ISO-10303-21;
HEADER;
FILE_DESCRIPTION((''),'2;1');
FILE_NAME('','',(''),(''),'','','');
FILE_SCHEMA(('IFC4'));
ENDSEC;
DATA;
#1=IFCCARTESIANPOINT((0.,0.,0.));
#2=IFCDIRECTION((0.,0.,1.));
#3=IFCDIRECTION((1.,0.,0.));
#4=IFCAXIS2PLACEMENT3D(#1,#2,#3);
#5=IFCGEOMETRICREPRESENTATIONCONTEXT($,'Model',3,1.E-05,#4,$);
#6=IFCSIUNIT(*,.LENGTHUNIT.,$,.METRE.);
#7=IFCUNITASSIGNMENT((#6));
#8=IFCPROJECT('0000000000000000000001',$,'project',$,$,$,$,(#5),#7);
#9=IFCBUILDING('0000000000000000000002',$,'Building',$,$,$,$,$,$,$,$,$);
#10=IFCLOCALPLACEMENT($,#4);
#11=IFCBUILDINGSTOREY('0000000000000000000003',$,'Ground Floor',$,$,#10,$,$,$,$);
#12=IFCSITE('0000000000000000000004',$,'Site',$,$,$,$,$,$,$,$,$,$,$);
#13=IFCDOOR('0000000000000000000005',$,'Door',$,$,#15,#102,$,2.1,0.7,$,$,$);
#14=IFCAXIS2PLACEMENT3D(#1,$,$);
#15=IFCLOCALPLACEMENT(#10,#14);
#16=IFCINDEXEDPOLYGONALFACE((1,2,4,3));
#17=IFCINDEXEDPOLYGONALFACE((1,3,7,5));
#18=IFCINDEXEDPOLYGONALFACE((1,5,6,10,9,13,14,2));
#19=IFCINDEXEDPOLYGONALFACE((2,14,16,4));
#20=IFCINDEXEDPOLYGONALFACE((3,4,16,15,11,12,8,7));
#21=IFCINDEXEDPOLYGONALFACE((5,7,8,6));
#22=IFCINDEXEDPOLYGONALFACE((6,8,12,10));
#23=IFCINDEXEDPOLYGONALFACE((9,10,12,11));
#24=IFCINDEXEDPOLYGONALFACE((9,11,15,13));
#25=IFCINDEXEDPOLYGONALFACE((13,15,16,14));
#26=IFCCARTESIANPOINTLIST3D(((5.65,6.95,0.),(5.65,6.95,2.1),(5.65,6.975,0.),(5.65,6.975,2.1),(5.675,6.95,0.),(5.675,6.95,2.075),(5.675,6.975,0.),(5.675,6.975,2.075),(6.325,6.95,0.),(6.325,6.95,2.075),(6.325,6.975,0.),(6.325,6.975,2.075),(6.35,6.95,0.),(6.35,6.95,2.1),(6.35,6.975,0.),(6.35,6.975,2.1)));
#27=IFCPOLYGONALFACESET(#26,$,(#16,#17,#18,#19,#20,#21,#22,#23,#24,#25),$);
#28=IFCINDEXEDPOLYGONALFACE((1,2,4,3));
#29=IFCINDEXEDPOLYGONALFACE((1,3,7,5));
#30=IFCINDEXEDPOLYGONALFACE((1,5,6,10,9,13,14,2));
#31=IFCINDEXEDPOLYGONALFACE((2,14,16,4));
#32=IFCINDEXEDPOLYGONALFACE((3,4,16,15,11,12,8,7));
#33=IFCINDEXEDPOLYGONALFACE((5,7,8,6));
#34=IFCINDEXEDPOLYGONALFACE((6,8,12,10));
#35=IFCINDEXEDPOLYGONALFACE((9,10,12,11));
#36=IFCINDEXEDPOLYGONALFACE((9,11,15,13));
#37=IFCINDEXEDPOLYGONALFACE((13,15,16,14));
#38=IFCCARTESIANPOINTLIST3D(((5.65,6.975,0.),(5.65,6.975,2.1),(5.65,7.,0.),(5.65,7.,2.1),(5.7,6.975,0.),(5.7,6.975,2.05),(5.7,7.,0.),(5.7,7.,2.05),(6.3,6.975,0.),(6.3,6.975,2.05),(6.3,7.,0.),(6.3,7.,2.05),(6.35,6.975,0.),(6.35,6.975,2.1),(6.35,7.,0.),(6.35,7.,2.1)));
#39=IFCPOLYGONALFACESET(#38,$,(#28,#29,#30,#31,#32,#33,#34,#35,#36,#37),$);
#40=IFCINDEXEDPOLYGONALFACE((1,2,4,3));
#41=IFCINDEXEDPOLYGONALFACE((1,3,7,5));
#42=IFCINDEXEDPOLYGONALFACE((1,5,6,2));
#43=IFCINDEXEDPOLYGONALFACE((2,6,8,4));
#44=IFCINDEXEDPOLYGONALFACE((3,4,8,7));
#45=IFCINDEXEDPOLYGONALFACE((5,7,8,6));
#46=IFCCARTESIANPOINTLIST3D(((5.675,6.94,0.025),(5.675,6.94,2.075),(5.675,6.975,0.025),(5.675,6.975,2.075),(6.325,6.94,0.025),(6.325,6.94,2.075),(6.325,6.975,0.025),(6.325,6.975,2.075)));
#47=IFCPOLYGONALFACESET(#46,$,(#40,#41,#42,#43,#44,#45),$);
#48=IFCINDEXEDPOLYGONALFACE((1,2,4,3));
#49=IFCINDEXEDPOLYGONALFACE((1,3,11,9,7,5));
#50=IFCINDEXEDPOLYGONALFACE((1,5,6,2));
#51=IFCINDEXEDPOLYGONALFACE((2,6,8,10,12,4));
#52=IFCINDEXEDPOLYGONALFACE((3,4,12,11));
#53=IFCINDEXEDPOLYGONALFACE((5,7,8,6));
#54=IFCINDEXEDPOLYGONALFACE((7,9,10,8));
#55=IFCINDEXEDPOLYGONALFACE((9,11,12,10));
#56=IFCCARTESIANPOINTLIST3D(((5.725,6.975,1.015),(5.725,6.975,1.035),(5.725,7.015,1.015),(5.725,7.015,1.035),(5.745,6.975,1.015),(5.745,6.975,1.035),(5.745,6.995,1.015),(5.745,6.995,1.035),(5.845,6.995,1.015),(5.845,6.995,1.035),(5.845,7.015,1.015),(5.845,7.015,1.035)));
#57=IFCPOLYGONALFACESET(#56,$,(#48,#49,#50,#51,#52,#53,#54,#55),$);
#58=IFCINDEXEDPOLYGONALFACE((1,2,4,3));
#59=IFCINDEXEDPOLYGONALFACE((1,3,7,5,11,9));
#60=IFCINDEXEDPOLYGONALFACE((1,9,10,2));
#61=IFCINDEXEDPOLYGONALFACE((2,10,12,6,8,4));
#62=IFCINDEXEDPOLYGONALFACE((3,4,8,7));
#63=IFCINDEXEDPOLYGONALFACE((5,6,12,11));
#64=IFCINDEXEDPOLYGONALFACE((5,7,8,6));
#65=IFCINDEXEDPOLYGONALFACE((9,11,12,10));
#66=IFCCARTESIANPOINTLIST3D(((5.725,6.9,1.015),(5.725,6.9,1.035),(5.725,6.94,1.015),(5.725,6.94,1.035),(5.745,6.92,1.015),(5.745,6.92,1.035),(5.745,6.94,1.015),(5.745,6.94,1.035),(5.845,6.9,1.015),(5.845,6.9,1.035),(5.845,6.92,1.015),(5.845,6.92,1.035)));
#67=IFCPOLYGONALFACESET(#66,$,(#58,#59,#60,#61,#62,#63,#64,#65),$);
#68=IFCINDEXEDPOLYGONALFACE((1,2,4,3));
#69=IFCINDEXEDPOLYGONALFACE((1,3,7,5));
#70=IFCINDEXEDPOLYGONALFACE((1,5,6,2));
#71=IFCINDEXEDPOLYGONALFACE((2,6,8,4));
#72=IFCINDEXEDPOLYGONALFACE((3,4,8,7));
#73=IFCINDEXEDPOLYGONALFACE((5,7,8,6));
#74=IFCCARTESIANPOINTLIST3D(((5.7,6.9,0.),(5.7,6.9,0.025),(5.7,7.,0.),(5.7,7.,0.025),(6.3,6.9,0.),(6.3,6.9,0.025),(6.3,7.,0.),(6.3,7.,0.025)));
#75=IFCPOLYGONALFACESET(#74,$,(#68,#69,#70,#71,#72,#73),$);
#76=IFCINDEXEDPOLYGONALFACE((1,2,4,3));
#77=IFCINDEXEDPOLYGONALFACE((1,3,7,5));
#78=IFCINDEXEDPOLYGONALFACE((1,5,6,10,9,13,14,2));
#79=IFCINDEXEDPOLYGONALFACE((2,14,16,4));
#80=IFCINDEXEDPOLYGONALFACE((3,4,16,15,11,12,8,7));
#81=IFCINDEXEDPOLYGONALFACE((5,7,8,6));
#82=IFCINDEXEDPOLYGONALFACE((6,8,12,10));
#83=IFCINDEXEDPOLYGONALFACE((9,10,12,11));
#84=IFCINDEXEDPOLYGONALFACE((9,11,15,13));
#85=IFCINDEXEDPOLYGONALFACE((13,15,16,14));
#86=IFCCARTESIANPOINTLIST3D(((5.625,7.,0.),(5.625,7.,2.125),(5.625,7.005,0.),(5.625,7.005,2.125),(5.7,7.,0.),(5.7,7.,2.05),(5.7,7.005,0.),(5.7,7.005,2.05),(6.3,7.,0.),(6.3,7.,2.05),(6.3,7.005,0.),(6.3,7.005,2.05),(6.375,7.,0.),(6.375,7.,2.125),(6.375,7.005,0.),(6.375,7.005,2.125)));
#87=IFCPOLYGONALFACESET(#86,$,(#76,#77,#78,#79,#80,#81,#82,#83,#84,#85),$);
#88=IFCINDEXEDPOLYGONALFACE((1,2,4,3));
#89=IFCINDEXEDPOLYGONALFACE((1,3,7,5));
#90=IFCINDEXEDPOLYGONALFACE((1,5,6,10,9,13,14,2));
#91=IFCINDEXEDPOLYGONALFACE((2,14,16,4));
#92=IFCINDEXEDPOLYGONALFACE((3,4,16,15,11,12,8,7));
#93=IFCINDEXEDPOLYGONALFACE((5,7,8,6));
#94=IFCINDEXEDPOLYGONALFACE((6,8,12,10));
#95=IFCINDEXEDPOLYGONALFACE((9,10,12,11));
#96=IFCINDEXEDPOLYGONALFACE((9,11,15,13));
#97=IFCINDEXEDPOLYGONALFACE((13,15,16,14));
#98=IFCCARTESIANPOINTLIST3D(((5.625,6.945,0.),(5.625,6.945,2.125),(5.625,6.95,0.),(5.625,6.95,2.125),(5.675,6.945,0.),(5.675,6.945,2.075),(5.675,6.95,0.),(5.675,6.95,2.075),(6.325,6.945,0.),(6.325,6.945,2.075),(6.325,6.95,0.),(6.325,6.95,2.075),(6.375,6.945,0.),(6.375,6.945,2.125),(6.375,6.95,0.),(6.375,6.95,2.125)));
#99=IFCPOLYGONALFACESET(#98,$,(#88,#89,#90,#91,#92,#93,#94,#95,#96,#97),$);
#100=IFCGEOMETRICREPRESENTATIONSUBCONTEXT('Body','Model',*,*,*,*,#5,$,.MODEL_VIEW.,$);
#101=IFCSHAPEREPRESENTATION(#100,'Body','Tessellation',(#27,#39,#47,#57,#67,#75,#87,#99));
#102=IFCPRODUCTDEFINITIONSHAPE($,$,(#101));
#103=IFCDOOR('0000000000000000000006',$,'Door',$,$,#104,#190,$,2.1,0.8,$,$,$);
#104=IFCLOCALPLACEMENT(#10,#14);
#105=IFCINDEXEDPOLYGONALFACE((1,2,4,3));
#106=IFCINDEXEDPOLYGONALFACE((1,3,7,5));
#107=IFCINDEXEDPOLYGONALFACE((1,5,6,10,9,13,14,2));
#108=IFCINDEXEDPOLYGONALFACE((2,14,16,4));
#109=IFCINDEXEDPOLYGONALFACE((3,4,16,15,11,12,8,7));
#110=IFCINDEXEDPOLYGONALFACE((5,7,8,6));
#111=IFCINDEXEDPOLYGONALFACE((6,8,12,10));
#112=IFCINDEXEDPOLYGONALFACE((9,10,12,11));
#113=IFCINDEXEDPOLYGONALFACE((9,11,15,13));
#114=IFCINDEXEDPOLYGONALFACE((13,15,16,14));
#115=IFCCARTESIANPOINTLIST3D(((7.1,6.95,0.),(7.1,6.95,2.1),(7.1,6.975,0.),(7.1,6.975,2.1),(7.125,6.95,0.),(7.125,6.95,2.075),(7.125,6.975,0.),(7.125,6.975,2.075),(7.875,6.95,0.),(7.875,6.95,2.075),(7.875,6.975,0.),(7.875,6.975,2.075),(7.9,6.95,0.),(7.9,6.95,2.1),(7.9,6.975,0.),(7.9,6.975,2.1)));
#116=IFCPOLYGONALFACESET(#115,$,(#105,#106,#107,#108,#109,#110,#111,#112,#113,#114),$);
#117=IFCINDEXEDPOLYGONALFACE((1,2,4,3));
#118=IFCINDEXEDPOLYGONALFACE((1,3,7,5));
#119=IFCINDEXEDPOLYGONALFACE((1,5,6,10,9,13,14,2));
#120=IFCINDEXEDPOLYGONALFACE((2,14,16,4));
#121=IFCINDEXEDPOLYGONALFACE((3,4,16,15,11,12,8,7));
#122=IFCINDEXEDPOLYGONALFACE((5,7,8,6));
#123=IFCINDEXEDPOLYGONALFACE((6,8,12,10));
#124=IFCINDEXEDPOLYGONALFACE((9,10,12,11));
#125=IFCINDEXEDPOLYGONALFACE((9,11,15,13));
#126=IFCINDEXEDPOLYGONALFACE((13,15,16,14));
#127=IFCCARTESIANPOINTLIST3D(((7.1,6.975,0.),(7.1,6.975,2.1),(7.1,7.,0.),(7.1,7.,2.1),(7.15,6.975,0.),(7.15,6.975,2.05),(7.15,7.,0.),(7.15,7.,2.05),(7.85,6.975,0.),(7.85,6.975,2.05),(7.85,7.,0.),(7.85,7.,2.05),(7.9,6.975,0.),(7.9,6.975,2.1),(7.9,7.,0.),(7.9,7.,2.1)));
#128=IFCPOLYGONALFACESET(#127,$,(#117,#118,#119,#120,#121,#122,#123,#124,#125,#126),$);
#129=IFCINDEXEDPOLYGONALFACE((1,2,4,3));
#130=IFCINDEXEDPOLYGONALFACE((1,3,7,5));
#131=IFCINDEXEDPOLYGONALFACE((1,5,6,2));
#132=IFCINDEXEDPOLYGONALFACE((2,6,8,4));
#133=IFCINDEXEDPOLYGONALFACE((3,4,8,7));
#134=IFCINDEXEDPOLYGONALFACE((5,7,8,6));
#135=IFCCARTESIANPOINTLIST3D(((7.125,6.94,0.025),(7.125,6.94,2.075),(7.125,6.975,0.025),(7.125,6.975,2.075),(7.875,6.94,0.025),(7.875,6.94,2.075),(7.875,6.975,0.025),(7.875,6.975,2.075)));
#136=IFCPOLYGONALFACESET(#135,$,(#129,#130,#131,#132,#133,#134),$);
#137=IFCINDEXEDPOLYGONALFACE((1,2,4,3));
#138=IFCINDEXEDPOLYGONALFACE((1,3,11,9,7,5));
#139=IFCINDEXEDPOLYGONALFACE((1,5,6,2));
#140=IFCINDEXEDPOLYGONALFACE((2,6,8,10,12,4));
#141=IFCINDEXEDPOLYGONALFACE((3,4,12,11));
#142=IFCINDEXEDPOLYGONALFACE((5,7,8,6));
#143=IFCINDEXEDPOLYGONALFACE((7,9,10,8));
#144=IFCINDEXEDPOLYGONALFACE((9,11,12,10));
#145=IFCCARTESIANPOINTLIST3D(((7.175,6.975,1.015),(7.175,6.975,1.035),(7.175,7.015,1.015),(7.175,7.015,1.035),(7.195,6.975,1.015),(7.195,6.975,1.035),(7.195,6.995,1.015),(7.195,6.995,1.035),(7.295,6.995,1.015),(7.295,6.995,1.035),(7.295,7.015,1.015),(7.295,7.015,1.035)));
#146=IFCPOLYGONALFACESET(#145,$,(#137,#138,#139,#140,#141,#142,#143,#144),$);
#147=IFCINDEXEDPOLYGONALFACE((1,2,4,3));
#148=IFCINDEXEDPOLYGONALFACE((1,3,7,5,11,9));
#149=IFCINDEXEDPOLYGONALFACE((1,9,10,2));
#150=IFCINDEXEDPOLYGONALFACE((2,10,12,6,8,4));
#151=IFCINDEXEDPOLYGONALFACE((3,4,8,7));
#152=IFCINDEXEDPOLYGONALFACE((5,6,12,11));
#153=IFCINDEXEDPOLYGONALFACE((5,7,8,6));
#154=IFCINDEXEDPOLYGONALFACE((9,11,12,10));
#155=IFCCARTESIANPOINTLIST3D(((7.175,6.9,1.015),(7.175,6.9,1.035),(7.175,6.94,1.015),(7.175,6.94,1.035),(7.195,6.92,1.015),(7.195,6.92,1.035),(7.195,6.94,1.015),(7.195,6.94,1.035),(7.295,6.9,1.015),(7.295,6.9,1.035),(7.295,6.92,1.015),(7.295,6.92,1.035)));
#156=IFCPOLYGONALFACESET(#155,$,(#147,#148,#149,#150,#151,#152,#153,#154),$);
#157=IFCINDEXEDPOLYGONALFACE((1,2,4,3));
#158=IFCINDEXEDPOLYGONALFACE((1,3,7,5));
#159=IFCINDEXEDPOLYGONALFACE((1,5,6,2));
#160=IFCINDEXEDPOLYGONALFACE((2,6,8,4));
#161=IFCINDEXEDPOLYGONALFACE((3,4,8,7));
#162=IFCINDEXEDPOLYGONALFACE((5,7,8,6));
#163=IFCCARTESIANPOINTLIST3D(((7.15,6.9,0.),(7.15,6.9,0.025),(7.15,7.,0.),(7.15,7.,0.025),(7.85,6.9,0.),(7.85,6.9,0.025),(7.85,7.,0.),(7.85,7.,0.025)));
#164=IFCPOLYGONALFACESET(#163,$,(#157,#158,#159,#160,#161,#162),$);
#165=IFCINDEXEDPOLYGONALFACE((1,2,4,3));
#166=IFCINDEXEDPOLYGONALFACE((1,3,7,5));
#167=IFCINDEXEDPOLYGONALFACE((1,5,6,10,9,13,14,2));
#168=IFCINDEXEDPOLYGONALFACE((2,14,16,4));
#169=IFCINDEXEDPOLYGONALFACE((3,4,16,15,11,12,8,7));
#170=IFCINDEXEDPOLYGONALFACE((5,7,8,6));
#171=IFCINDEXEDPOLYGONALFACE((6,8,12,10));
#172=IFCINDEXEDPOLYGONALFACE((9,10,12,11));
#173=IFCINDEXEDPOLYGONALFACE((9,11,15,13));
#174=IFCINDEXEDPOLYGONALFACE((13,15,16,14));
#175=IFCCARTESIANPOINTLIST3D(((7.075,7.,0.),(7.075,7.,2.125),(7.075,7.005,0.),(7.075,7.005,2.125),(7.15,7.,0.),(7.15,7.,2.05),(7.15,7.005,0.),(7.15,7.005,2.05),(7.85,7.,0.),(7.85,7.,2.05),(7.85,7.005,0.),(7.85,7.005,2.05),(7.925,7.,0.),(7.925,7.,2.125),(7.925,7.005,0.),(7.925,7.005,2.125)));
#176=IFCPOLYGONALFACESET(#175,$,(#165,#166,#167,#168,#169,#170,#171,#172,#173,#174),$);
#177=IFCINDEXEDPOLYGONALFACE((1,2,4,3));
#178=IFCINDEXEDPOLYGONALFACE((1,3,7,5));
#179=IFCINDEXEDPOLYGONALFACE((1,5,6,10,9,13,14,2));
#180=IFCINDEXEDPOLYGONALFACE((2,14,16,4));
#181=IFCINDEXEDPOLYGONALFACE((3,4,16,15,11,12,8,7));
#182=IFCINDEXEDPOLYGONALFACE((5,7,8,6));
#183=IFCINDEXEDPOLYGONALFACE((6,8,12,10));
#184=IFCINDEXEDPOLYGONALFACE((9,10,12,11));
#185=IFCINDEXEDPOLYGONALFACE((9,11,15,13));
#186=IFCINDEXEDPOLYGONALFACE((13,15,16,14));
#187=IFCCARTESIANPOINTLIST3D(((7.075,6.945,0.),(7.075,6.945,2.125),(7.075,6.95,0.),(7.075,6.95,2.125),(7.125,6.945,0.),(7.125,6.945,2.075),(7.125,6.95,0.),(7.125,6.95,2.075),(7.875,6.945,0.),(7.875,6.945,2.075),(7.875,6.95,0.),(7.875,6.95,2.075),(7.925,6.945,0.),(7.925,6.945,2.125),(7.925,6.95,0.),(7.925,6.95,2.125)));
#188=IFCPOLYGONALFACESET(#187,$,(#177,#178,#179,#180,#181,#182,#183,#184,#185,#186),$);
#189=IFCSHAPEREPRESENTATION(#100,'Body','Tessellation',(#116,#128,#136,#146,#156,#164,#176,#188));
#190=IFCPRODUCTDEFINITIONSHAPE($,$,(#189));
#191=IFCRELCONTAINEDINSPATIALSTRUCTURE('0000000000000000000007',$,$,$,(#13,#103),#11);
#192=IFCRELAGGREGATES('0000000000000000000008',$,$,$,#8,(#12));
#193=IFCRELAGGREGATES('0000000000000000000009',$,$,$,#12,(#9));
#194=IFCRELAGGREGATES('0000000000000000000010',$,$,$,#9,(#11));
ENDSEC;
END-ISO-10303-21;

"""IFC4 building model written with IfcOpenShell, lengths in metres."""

from ifc_helpers import new_model, si_unit, frame, origin_with_axes, place, context, subcontext, project, spatial, line, indexed_curve, outline, extrude, element, save


model = new_model("IFC4")

# Units and contexts
model_context = context("Model", 3, precision=1e-05, world=origin_with_axes())
body_context = subcontext(model_context, "Body", "Model", "MODEL_VIEW")
ifc_project = project(units=[si_unit("LENGTHUNIT", "METRE")], contexts=[model_context])

# Site, building, storey
site = spatial("IfcSite", under=ifc_project, Name="Site")
building = spatial("IfcBuilding", under=site, Name="Building")
storey_placement = place(None, origin_with_axes())
storey = spatial("IfcBuildingStorey", under=building, at=storey_placement, Name="Ground Floor")

# Doors
door_1_placement = place(storey_placement, frame((6.35, 7.0, 0.0), z_axis=(0.0, 0.0, 1.0), x_axis=(-1.0, 0.0, 0.0)))
element("IfcDoor", 1, at=door_1_placement, inside=storey, Name="Door", OverallHeight=2.1, OverallWidth=0.7, context=body_context, shape_type="SweptSolid", body=[
    extrude(outline(indexed_curve([(0.0, 0.0), (0.0, 2.1), (0.7, 2.1), (0.7, 0.0), (0.675, 0.0), (0.675, 2.075), (0.025, 2.075), (0.025, 0.0)], segments=[line(1, 2, 3, 4, 5, 6, 7, 8, 1)])), frame((0.0, 0.025, 0.0), z_axis=(0.0, -1.0, 0.0), x_axis=(1.0, 0.0, 0.0)), (0.0, 0.0, -1.0), 0.025),
    extrude(outline(indexed_curve([(0.0, 0.0), (0.0, 2.1), (0.7, 2.1), (0.7, 0.0), (0.65, 0.0), (0.65, 2.05), (0.05, 2.05), (0.05, 0.0)], segments=[line(1, 2, 3, 4, 5, 6, 7, 8, 1)])), frame((0.0, 0.0, 0.0), z_axis=(0.0, -1.0, 0.0), x_axis=(1.0, 0.0, 0.0)), (0.0, 0.0, -1.0), 0.025),
    extrude(outline(indexed_curve([(0.0, 0.0), (0.65, 0.0), (0.65, 0.035), (0.0, 0.035)], segments=[line(1, 2, 3, 4, 1)])), frame((0.025, 0.025, 0.025), z_axis=(0.0, 0.0, 1.0), x_axis=(1.0, 0.0, 0.0)), (0.0, 0.0, 1.0), 2.05),
    extrude(outline(indexed_curve([(0.0, 0.0), (0.0, -0.04), (-0.12, -0.04), (-0.12, -0.02), (-0.02, -0.02), (-0.02, 0.0)], segments=[line(1, 2, 3, 4, 5, 6, 1)])), frame((0.625, 0.025, 1.015), z_axis=(0.0, 0.0, 1.0), x_axis=(1.0, 0.0, 0.0)), (0.0, 0.0, 1.0), 0.02),
    extrude(outline(indexed_curve([(0.0, 0.0), (0.0, 0.04), (-0.12, 0.04), (-0.12, 0.02), (-0.02, 0.02), (-0.02, 0.0)], segments=[line(1, 2, 3, 4, 5, 6, 1)])), frame((0.625, 0.06, 1.015), z_axis=(0.0, 0.0, 1.0), x_axis=(1.0, 0.0, 0.0)), (0.0, 0.0, 1.0), 0.02),
    extrude(outline(indexed_curve([(0.0, 0.0), (0.6, 0.0), (0.6, 0.1), (0.0, 0.1)], segments=[line(1, 2, 3, 4, 1)])), frame((0.05, 0.0, 0.0), z_axis=(0.0, 0.0, 1.0), x_axis=(1.0, 0.0, 0.0)), (0.0, 0.0, 1.0), 0.025),
    extrude(outline(indexed_curve([(0.0, 0.0), (0.0, 2.125), (0.75, 2.125), (0.75, 0.0), (0.675, 0.0), (0.675, 2.05), (0.075, 2.05), (0.075, 0.0)], segments=[line(1, 2, 3, 4, 5, 6, 7, 8, 1)])), frame((-0.025, -0.005, 0.0), z_axis=(0.0, -1.0, 0.0), x_axis=(1.0, 0.0, 0.0)), (0.0, 0.0, -1.0), 0.005),
    extrude(outline(indexed_curve([(0.0, 0.0), (0.0, 2.125), (0.75, 2.125), (0.75, 0.0), (0.7, 0.0), (0.7, 2.075), (0.05, 2.075), (0.05, 0.0)], segments=[line(1, 2, 3, 4, 5, 6, 7, 8, 1)])), frame((-0.025, 0.05, 0.0), z_axis=(0.0, -1.0, 0.0), x_axis=(1.0, 0.0, 0.0)), (0.0, 0.0, -1.0), 0.005),
])
door_2_placement = place(storey_placement, frame((7.9, 7.0, 0.0), z_axis=(0.0, 0.0, 1.0), x_axis=(-1.0, 0.0, 0.0)))
element("IfcDoor", 2, at=door_2_placement, inside=storey, Name="Door", OverallHeight=2.1, OverallWidth=0.8, context=body_context, shape_type="SweptSolid", body=[
    extrude(outline(indexed_curve([(0.0, 0.0), (0.0, 2.1), (0.8, 2.1), (0.8, 0.0), (0.775, 0.0), (0.775, 2.075), (0.025, 2.075), (0.025, 0.0)], segments=[line(1, 2, 3, 4, 5, 6, 7, 8, 1)])), frame((0.0, 0.025, 0.0), z_axis=(0.0, -1.0, 0.0), x_axis=(1.0, 0.0, 0.0)), (0.0, 0.0, -1.0), 0.025),
    extrude(outline(indexed_curve([(0.0, 0.0), (0.0, 2.1), (0.8, 2.1), (0.8, 0.0), (0.75, 0.0), (0.75, 2.05), (0.05, 2.05), (0.05, 0.0)], segments=[line(1, 2, 3, 4, 5, 6, 7, 8, 1)])), frame((0.0, 0.0, 0.0), z_axis=(0.0, -1.0, 0.0), x_axis=(1.0, 0.0, 0.0)), (0.0, 0.0, -1.0), 0.025),
    extrude(outline(indexed_curve([(0.0, 0.0), (0.75, 0.0), (0.75, 0.035), (0.0, 0.035)], segments=[line(1, 2, 3, 4, 1)])), frame((0.025, 0.025, 0.025), z_axis=(0.0, 0.0, 1.0), x_axis=(1.0, 0.0, 0.0)), (0.0, 0.0, 1.0), 2.05),
    extrude(outline(indexed_curve([(0.0, 0.0), (0.0, -0.04), (-0.12, -0.04), (-0.12, -0.02), (-0.02, -0.02), (-0.02, 0.0)], segments=[line(1, 2, 3, 4, 5, 6, 1)])), frame((0.725, 0.025, 1.015), z_axis=(0.0, 0.0, 1.0), x_axis=(1.0, 0.0, 0.0)), (0.0, 0.0, 1.0), 0.02),
    extrude(outline(indexed_curve([(0.0, 0.0), (0.0, 0.04), (-0.12, 0.04), (-0.12, 0.02), (-0.02, 0.02), (-0.02, 0.0)], segments=[line(1, 2, 3, 4, 5, 6, 1)])), frame((0.725, 0.06, 1.015), z_axis=(0.0, 0.0, 1.0), x_axis=(1.0, 0.0, 0.0)), (0.0, 0.0, 1.0), 0.02),
    extrude(outline(indexed_curve([(0.0, 0.0), (0.7, 0.0), (0.7, 0.1), (0.0, 0.1)], segments=[line(1, 2, 3, 4, 1)])), frame((0.05, 0.0, 0.0), z_axis=(0.0, 0.0, 1.0), x_axis=(1.0, 0.0, 0.0)), (0.0, 0.0, 1.0), 0.025),
    extrude(outline(indexed_curve([(0.0, 0.0), (0.0, 2.125), (0.85, 2.125), (0.85, 0.0), (0.775, 0.0), (0.775, 2.05), (0.075, 2.05), (0.075, 0.0)], segments=[line(1, 2, 3, 4, 5, 6, 7, 8, 1)])), frame((-0.025, -0.005, 0.0), z_axis=(0.0, -1.0, 0.0), x_axis=(1.0, 0.0, 0.0)), (0.0, 0.0, -1.0), 0.005),
    extrude(outline(indexed_curve([(0.0, 0.0), (0.0, 2.125), (0.85, 2.125), (0.85, 0.0), (0.8, 0.0), (0.8, 2.075), (0.05, 2.075), (0.05, 0.0)], segments=[line(1, 2, 3, 4, 5, 6, 7, 8, 1)])), frame((-0.025, 0.05, 0.0), z_axis=(0.0, -1.0, 0.0), x_axis=(1.0, 0.0, 0.0)), (0.0, 0.0, -1.0), 0.005),
])

save(model, "model.ifc")
